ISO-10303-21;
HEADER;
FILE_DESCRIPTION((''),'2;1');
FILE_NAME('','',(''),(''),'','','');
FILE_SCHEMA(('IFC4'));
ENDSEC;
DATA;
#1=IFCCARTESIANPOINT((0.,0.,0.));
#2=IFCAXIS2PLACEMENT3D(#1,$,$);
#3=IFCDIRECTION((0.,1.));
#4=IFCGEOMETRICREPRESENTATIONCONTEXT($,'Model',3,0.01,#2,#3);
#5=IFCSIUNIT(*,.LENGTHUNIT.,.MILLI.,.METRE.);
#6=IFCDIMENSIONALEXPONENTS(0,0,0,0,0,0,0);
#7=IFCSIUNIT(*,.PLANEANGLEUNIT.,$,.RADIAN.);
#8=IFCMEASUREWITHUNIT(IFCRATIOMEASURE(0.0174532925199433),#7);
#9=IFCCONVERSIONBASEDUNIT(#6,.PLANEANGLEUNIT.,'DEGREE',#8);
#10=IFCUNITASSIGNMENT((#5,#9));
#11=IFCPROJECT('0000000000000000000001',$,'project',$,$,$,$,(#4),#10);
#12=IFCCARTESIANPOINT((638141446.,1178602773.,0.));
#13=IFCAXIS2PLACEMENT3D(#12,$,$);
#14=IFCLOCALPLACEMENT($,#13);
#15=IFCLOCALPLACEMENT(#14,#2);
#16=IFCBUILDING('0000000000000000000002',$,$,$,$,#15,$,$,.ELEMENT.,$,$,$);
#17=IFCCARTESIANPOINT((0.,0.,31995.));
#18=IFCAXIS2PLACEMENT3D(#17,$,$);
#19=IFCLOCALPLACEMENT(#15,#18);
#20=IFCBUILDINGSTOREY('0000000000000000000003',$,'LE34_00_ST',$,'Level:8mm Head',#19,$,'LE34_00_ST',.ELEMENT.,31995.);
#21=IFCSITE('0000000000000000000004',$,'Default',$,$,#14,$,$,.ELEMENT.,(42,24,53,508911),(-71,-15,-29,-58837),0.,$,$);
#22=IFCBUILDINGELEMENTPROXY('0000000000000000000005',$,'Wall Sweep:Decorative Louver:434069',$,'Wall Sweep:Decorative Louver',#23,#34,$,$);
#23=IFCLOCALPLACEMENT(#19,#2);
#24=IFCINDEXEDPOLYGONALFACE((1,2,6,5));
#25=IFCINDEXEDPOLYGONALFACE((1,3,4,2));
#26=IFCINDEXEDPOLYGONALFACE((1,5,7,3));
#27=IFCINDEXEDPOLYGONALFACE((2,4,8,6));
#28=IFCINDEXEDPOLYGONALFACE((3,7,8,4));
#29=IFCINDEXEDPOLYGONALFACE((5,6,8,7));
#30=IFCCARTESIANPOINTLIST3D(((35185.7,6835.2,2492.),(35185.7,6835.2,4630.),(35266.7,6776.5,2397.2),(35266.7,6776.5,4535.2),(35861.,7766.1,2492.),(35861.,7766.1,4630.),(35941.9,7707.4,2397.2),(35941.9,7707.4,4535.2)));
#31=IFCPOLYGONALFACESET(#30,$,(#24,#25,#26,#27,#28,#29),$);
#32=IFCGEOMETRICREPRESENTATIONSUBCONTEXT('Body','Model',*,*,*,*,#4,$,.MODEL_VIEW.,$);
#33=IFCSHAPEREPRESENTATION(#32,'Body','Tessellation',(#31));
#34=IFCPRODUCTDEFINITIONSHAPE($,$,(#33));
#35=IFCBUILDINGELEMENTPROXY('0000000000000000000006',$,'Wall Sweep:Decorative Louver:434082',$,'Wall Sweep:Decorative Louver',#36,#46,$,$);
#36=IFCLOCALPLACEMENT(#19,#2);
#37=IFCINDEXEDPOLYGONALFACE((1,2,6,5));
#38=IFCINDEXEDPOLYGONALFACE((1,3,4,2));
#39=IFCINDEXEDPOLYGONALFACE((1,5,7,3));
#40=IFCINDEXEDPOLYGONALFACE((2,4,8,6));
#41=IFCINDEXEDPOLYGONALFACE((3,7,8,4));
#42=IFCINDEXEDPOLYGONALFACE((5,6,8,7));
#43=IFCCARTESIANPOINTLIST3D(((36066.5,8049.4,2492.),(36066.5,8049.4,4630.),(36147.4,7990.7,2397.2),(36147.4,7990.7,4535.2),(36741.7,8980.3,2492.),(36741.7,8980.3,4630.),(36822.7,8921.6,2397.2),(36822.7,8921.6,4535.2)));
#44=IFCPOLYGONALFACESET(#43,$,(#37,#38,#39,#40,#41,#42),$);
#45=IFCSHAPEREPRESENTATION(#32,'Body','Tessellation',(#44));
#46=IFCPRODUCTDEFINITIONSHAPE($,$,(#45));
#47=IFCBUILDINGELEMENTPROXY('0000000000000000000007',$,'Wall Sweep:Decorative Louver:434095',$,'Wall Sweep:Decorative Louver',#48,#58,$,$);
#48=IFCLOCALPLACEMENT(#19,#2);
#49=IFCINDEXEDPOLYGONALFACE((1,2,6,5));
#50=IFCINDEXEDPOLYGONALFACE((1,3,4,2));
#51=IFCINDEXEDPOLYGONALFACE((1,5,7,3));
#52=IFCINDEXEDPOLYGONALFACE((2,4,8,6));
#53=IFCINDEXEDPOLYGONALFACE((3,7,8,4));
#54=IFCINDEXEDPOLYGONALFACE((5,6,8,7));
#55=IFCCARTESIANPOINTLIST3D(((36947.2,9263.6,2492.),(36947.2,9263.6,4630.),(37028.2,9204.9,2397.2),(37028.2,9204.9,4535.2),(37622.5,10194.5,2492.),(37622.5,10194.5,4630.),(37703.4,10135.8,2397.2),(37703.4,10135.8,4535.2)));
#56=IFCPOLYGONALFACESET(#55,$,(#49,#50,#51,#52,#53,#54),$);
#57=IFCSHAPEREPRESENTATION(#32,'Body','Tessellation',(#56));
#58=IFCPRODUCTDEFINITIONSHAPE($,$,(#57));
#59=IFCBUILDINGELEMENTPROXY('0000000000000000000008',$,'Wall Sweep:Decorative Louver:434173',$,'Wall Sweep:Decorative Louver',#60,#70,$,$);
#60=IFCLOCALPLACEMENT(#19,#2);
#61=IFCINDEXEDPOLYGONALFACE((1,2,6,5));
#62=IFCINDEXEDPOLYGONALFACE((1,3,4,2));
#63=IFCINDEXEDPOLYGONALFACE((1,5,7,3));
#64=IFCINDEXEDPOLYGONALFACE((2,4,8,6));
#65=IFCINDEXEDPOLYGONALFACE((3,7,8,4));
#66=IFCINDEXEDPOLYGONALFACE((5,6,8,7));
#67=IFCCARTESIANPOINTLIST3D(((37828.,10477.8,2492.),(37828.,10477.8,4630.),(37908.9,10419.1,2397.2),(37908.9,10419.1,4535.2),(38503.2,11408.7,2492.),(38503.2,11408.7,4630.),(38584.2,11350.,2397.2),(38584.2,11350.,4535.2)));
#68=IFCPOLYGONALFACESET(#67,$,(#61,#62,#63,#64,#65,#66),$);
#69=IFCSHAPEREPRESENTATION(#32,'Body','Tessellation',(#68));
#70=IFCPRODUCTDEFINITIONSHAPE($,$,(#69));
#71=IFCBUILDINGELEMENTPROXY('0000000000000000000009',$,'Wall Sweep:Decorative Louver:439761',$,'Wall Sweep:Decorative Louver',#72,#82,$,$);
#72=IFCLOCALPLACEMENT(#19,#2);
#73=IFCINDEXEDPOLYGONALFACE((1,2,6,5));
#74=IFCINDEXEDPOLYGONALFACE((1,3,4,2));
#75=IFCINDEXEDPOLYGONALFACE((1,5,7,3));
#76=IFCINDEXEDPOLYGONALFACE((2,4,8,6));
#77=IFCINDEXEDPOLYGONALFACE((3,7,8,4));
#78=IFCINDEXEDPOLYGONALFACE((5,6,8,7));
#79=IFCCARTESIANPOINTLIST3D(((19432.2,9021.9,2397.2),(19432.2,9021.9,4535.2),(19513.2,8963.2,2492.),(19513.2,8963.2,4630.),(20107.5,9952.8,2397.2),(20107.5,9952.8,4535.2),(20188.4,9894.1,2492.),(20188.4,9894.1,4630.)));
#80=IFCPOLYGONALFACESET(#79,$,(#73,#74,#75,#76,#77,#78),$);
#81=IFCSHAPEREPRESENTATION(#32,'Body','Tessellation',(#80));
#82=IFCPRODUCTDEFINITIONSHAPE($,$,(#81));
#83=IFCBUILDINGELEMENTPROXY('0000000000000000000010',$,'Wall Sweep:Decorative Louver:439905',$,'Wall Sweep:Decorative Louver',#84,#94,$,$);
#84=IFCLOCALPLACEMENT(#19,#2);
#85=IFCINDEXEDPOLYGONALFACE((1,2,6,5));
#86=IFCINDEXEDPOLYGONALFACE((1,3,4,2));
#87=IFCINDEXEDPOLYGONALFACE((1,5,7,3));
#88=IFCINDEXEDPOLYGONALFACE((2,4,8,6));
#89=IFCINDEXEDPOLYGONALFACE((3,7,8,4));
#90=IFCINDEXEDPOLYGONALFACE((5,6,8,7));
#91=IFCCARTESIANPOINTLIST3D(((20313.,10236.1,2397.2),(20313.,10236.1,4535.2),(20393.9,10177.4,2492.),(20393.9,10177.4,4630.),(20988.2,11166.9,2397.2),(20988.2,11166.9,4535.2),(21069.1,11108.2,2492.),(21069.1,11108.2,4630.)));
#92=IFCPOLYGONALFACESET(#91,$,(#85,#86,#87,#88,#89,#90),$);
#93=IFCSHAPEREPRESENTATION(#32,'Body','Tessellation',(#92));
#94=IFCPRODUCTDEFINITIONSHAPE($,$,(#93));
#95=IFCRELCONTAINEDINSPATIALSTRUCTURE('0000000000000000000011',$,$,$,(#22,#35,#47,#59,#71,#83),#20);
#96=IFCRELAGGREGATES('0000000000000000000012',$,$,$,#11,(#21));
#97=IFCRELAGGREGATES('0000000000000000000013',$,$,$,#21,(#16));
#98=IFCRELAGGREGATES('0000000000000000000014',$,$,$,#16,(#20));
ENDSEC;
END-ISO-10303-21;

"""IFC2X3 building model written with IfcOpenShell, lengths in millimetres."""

from ifc_helpers import new_model, entity, si_unit, converted_unit, direction, frame, origin, place, context, subcontext, project, spatial, polyline, outline, extrude, element, save


model = new_model("IFC2X3")

# Units and contexts
model_context = context("Model", 3, precision=0.01, world=origin(), true_north=direction((0.0, 1.0)))
body_context = subcontext(model_context, "Body", "Model", "MODEL_VIEW")
ifc_project = project(units=[si_unit("LENGTHUNIT", "METRE", prefix="MILLI"), converted_unit("PLANEANGLEUNIT", "DEGREE", entity("IfcRatioMeasure", 0.0174532925199433), si_unit("PLANEANGLEUNIT", "RADIAN"), dimensions=[0, 0, 0, 0, 0, 0, 0])], contexts=[model_context])

# Site, building, storey
site_placement = place(None, frame((638141446.0, 1178602773.0, 0.0)))
site = spatial("IfcSite", under=ifc_project, at=site_placement, Name="Default", CompositionType="ELEMENT", RefLatitude=(42, 24, 53, 508911), RefLongitude=(-71, -15, -29, -58837), RefElevation=0.0)
building_placement = place(site_placement, origin())
building = spatial("IfcBuilding", under=site, at=building_placement, CompositionType="ELEMENT")
storey_placement = place(building_placement, frame((0.0, 0.0, 31995.0)))
storey = spatial("IfcBuildingStorey", under=building, at=storey_placement, Name="LE34_00_ST", ObjectType="Level:8mm Head", LongName="LE34_00_ST", CompositionType="ELEMENT", Elevation=31995.0)

# Building element proxies
proxy_1_placement = place(storey_placement, origin())
element("IfcBuildingElementProxy", 1, at=proxy_1_placement, inside=storey, Name="Wall Sweep:Decorative Louver:434069", ObjectType="Wall Sweep:Decorative Louver", context=body_context, shape_type="SweptSolid", body=[
    extrude(outline(polyline([(-1021.6, -50.0), (1116.4, -50.0), (1021.6, 50.0), (-1116.4, 50.0), (-1021.6, -50.0)])), frame((35226.2, 6805.9, 3513.6), z_axis=(0.587164, 0.809468, 0.0), x_axis=(0.0, 0.0, -1.0)), (0.0, 0.0, 1.0), 1150.0),
])
proxy_2_placement = place(storey_placement, origin())
element("IfcBuildingElementProxy", 2, at=proxy_2_placement, inside=storey, Name="Wall Sweep:Decorative Louver:434082", ObjectType="Wall Sweep:Decorative Louver", context=body_context, shape_type="SweptSolid", body=[
    extrude(outline(polyline([(-1021.6, -50.0), (1116.4, -50.0), (1021.6, 50.0), (-1116.4, 50.0), (-1021.6, -50.0)])), frame((36107.0, 8020.1, 3513.6), z_axis=(0.587164, 0.809468, 0.0), x_axis=(0.0, 0.0, -1.0)), (0.0, 0.0, 1.0), 1150.0),
])
proxy_3_placement = place(storey_placement, origin())
element("IfcBuildingElementProxy", 3, at=proxy_3_placement, inside=storey, Name="Wall Sweep:Decorative Louver:434095", ObjectType="Wall Sweep:Decorative Louver", context=body_context, shape_type="SweptSolid", body=[
    extrude(outline(polyline([(-1021.6, -50.0), (1116.4, -50.0), (1021.6, 50.0), (-1116.4, 50.0), (-1021.6, -50.0)])), frame((36987.7, 9234.3, 3513.6), z_axis=(0.587164, 0.809468, 0.0), x_axis=(0.0, 0.0, -1.0)), (0.0, 0.0, 1.0), 1150.0),
])
proxy_4_placement = place(storey_placement, origin())
element("IfcBuildingElementProxy", 4, at=proxy_4_placement, inside=storey, Name="Wall Sweep:Decorative Louver:434173", ObjectType="Wall Sweep:Decorative Louver", context=body_context, shape_type="SweptSolid", body=[
    extrude(outline(polyline([(-1021.6, -50.0), (1116.4, -50.0), (1021.6, 50.0), (-1116.4, 50.0), (-1021.6, -50.0)])), frame((37868.5, 10448.5, 3513.6), z_axis=(0.587164, 0.809468, 0.0), x_axis=(0.0, 0.0, -1.0)), (0.0, 0.0, 1.0), 1150.0),
])
proxy_5_placement = place(storey_placement, origin())
element("IfcBuildingElementProxy", 5, at=proxy_5_placement, inside=storey, Name="Wall Sweep:Decorative Louver:439761", ObjectType="Wall Sweep:Decorative Louver", context=body_context, shape_type="SweptSolid", body=[
    extrude(outline(polyline([(666.6, -775.8), (804.4, -775.8), (-666.6, 775.8), (-804.4, 775.8), (666.6, -775.8)])), frame((19472.7, 8992.5, 3513.6), z_axis=(0.587164, 0.809468, 0.0), x_axis=(0.58745, -0.426119, 0.687986)), (0.0, 0.0, 1.0), 1150.0),
])
proxy_6_placement = place(storey_placement, origin())
element("IfcBuildingElementProxy", 6, at=proxy_6_placement, inside=storey, Name="Wall Sweep:Decorative Louver:439905", ObjectType="Wall Sweep:Decorative Louver", context=body_context, shape_type="SweptSolid", body=[
    extrude(outline(polyline([(666.6, -775.8), (804.4, -775.8), (-666.6, 775.8), (-804.4, 775.8), (666.6, -775.8)])), frame((20353.4, 10206.7, 3513.6), z_axis=(0.587164, 0.809468, 0.0), x_axis=(0.58745, -0.426119, 0.687986)), (0.0, 0.0, 1.0), 1149.9),
])

save(model, "model.ifc")
